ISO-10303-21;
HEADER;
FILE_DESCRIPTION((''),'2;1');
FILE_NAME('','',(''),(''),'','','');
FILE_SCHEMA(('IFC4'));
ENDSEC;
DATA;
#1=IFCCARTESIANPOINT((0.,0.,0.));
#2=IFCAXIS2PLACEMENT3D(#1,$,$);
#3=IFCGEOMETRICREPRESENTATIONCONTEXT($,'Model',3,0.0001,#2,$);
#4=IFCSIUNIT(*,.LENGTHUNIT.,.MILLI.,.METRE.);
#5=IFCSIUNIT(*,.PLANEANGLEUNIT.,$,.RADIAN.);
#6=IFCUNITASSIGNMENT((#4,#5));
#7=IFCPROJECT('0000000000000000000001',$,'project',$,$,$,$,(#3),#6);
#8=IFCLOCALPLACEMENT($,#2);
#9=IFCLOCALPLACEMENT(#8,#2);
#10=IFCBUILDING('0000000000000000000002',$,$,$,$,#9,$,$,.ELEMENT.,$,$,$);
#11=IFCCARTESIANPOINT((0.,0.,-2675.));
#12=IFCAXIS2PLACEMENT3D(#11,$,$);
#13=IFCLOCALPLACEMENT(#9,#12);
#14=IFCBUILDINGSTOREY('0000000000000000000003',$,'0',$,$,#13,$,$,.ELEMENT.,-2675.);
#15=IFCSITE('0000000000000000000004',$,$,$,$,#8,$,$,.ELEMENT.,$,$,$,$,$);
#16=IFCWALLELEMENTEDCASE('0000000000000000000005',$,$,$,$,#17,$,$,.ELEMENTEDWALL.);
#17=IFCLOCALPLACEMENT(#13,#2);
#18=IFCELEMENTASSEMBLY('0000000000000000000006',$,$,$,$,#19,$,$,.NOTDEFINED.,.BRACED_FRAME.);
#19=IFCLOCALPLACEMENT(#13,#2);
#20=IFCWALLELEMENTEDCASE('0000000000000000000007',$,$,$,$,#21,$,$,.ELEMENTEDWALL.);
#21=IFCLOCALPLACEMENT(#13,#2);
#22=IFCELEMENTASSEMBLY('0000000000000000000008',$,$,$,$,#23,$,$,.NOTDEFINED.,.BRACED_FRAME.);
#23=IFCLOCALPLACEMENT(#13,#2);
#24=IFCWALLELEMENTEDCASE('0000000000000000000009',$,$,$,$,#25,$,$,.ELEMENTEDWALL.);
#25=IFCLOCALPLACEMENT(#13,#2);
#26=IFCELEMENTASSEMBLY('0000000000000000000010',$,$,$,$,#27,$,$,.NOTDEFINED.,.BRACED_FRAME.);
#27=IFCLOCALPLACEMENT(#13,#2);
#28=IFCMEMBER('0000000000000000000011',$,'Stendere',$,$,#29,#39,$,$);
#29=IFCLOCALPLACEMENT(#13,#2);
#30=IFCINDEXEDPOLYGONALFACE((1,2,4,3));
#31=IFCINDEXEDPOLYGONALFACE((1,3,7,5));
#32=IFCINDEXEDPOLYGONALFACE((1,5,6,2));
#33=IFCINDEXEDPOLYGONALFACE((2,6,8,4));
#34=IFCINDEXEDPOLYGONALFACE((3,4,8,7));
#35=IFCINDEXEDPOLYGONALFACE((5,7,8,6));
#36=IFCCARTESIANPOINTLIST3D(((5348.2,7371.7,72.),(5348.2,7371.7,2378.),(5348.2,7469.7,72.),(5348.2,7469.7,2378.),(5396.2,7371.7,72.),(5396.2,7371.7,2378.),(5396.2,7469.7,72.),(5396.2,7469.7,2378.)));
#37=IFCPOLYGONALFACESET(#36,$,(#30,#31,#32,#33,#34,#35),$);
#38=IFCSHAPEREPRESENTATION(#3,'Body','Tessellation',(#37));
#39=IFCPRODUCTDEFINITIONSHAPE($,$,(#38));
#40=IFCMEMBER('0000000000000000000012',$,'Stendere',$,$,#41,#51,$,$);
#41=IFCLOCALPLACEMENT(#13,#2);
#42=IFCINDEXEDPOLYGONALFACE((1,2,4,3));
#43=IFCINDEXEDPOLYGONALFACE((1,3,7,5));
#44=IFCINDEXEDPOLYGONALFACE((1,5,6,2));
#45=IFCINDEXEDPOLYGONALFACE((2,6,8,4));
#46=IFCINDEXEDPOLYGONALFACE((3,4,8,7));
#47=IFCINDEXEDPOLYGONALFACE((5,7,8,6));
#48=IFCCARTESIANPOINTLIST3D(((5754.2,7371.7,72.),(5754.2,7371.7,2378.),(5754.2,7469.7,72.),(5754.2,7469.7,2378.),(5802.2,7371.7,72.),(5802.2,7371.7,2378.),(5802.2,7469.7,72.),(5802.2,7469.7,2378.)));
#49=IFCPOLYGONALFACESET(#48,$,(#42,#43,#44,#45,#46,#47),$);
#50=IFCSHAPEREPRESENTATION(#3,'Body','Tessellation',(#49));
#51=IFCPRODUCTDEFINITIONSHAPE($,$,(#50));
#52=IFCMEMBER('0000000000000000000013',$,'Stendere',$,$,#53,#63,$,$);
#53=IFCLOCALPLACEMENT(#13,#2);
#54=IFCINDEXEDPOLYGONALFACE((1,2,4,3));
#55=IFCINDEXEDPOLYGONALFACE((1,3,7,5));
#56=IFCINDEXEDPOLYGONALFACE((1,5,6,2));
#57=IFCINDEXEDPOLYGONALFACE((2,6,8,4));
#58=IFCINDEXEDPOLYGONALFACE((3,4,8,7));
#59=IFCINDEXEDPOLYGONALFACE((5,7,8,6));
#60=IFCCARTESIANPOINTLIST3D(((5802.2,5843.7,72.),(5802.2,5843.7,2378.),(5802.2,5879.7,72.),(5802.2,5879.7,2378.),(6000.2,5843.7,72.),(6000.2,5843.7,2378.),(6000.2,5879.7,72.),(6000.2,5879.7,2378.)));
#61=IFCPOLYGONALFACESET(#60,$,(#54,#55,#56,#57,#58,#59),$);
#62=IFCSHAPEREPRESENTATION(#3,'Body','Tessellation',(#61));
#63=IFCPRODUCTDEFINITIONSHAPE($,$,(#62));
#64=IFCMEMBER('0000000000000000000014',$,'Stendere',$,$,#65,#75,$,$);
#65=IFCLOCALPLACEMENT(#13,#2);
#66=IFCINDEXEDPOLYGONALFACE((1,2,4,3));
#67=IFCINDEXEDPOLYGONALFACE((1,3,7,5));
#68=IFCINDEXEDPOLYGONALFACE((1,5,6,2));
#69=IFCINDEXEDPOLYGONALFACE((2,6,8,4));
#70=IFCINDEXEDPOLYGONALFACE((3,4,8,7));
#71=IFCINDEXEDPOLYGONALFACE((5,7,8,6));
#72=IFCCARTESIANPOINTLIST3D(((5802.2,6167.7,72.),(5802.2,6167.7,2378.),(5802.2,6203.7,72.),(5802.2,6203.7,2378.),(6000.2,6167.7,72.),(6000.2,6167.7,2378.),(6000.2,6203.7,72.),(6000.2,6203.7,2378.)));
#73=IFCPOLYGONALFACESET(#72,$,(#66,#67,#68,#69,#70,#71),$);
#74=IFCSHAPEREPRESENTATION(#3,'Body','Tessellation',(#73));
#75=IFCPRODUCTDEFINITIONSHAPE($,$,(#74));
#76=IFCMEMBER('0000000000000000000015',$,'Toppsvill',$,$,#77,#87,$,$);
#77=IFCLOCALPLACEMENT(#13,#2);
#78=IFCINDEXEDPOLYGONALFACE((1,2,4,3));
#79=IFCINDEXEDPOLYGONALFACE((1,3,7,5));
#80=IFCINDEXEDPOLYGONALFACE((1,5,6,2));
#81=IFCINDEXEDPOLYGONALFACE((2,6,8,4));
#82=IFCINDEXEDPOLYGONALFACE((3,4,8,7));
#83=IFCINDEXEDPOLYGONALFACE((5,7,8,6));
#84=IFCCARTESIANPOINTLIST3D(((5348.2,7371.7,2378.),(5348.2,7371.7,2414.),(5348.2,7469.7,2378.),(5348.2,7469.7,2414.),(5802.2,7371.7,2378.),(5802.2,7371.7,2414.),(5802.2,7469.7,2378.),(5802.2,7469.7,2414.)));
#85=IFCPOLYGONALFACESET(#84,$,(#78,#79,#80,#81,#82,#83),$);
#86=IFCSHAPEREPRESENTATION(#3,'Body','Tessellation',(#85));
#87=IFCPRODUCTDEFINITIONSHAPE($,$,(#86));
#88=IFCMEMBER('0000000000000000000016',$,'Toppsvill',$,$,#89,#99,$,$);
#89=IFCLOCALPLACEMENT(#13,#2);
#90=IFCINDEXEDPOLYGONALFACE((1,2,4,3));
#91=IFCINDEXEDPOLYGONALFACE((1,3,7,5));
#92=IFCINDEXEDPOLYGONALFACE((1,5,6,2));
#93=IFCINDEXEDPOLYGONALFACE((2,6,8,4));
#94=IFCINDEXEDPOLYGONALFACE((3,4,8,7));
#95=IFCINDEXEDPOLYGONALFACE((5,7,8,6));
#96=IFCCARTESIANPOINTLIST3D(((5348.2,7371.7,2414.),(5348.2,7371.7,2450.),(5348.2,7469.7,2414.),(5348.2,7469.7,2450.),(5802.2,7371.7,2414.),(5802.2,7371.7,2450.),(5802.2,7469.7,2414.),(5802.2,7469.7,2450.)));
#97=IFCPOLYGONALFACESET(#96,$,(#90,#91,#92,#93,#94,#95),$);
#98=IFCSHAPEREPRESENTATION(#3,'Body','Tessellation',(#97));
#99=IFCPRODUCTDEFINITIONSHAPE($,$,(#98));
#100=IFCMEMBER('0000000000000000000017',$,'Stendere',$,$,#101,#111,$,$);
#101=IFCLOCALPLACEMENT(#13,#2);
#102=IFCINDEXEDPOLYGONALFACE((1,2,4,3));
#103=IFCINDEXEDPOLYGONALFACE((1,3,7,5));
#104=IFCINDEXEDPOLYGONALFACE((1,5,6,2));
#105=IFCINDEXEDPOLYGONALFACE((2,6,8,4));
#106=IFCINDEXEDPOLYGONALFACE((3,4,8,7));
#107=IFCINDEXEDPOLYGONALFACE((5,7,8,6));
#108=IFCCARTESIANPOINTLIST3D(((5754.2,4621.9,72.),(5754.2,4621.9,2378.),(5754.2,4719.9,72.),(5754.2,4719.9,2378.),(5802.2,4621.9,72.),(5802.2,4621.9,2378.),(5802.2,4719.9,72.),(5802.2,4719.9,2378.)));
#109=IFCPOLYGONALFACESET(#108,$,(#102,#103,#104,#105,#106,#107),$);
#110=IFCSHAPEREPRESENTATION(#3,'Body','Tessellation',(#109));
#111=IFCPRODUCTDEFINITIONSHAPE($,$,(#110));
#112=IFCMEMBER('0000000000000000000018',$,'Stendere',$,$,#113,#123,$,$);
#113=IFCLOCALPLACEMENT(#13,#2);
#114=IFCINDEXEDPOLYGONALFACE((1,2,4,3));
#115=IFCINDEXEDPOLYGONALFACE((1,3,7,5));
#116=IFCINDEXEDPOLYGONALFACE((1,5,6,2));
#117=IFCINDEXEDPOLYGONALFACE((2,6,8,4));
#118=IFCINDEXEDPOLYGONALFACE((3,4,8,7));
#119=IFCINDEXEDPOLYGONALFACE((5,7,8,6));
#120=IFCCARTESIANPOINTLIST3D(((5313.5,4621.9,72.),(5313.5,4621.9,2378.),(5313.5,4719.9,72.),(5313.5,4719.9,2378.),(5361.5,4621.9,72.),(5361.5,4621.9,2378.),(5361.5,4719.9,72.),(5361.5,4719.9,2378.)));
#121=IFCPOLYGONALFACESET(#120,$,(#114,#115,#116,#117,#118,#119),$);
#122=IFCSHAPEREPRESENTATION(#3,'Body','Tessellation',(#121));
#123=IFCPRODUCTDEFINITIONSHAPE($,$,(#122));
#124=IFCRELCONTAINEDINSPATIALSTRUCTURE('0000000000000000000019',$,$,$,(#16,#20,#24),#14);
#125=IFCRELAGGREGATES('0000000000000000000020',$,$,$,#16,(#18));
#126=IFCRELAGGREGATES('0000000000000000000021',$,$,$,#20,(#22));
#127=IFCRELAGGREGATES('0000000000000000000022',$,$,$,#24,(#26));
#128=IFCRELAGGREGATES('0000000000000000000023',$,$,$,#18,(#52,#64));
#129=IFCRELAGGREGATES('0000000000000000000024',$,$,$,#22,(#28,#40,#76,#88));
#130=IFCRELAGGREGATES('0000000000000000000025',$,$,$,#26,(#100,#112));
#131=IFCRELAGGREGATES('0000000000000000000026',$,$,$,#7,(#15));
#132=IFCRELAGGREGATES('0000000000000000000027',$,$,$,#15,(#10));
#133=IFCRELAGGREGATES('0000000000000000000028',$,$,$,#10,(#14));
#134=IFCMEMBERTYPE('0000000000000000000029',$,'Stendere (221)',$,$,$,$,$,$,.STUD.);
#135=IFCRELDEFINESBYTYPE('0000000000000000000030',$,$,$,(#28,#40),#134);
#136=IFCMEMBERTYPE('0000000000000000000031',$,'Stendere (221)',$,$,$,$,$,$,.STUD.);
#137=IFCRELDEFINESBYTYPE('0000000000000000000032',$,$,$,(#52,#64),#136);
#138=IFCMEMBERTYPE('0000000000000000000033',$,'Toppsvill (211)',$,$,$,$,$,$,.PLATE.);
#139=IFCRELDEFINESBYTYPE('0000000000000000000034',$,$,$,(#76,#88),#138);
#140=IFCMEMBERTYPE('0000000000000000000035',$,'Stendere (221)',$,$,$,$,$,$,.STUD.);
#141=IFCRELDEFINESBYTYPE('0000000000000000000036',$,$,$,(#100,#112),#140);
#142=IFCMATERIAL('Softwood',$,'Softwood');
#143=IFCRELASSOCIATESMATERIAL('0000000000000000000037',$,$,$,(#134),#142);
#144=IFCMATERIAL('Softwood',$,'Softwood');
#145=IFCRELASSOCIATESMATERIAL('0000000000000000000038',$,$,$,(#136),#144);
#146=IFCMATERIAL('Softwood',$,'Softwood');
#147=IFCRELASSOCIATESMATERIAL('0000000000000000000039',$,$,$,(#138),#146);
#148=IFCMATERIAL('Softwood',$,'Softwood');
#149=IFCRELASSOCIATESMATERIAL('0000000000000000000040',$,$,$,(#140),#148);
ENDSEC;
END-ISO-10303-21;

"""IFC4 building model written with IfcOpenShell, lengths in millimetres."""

from ifc_helpers import new_model, si_unit, frame, origin, place, context, project, spatial, rectangle, extrude, clip, halfspace, material, material_profile, profile_set, type_object, element, aggregate, save


model = new_model("IFC4")

# Units and contexts
model_context = context("Model", 3, precision=0.0001, world=origin())
ifc_project = project(units=[si_unit("LENGTHUNIT", "METRE", prefix="MILLI"), si_unit("PLANEANGLEUNIT", "RADIAN")], contexts=[model_context])

# Site, building, storey
site_placement = place(None, origin())
site = spatial("IfcSite", under=ifc_project, at=site_placement, CompositionType="ELEMENT")
building_placement = place(site_placement, origin())
building = spatial("IfcBuilding", under=site, at=building_placement, CompositionType="ELEMENT")
storey_placement = place(building_placement, frame((0.0, 0.0, -2675.0)))
storey = spatial("IfcBuildingStorey", under=building, at=storey_placement, Name="0", CompositionType="ELEMENT", Elevation=-2675.0)

# Wall, element assembly
wall_1_placement = place(storey_placement, frame((6000.2, 7469.7, 0.0), z_axis=(-1.0, 0.0, 0.0), x_axis=(0.0, -1.0, 0.0)))
wall_1 = element("IfcWallElementedCase", 1, at=wall_1_placement, inside=storey, PredefinedType="ELEMENTEDWALL")
assembly_1_placement = place(wall_1_placement, origin())
assembly_1 = element("IfcElementAssembly", 2, at=assembly_1_placement, AssemblyPlace="NOTDEFINED", PredefinedType="BRACED_FRAME")
aggregate(wall_1, [assembly_1])

# Wall, element assembly
wall_2_placement = place(storey_placement, frame((5802.2, 7371.7, 0.0), z_axis=(0.0, 1.0, 0.0), x_axis=(-1.0, 0.0, 0.0)))
wall_2 = element("IfcWallElementedCase", 3, at=wall_2_placement, inside=storey, PredefinedType="ELEMENTEDWALL")
assembly_2_placement = place(wall_2_placement, origin())
assembly_2 = element("IfcElementAssembly", 4, at=assembly_2_placement, AssemblyPlace="NOTDEFINED", PredefinedType="BRACED_FRAME")
aggregate(wall_2, [assembly_2])

# Wall, element assembly
wall_3_placement = place(storey_placement, frame((352.0, 4719.9, 0.0), z_axis=(0.0, -1.0, 0.0)))
wall_3 = element("IfcWallElementedCase", 5, at=wall_3_placement, inside=storey, PredefinedType="ELEMENTEDWALL")
assembly_3_placement = place(wall_3_placement, origin())
assembly_3 = element("IfcElementAssembly", 6, at=assembly_3_placement, AssemblyPlace="NOTDEFINED", PredefinedType="BRACED_FRAME")
aggregate(wall_3, [assembly_3])
ifc_material_1 = material(Name="Softwood", Category="Softwood")
ifc_material_profile_1 = material_profile(ifc_material_1, rectangle(XDim=48.0, YDim=98.0), Name="Stendere (221)")
ifc_profile_set_1 = profile_set([ifc_material_profile_1])
member_type_1 = type_object("IfcMemberType", Name="Stendere (221)", PredefinedType="STUD", material=ifc_profile_set_1)

# Members
member_1_placement = place(assembly_2_placement, frame((430.0, 72.0, 0.0), z_axis=(0.0, 1.0, 0.0), x_axis=(-1.0, 0.0, 0.0)))
member_1 = element("IfcMember", 7, at=member_1_placement, type_object=member_type_1, Name="Stendere", context=model_context, shape_type="SweptSolid", body=[
    extrude(rectangle(XDim=48.0, YDim=98.0), frame((0.0, 49.0, 0.0)), (0.0, 0.0, 1.0), 2306.0),
])
member_2_placement = place(assembly_2_placement, frame((24.0, 72.0, 0.0), z_axis=(0.0, 1.0, 0.0), x_axis=(-1.0, 0.0, 0.0)))
member_2 = element("IfcMember", 8, at=member_2_placement, type_object=member_type_1, Name="Stendere", context=model_context, shape_type="SweptSolid", body=[
    extrude(rectangle(XDim=48.0, YDim=98.0), frame((0.0, 49.0, 0.0)), (0.0, 0.0, 1.0), 2306.0),
])
ifc_material_2 = material(Name="Softwood", Category="Softwood")
ifc_material_profile_2 = material_profile(ifc_material_2, rectangle(XDim=36.0, YDim=198.0), Name="Stendere (221)")
ifc_profile_set_2 = profile_set([ifc_material_profile_2])
member_type_2 = type_object("IfcMemberType", Name="Stendere (221)", PredefinedType="STUD", material=ifc_profile_set_2)
member_3_placement = place(assembly_1_placement, frame((1608.0, 72.0, 0.0), z_axis=(0.0, 1.0, 0.0), x_axis=(-1.0, 0.0, 0.0)))
member_3 = element("IfcMember", 9, at=member_3_placement, type_object=member_type_2, Name="Stendere", context=model_context, shape_type="SweptSolid", body=[
    extrude(rectangle(XDim=36.0, YDim=198.0), frame((0.0, 99.0, 0.0)), (0.0, 0.0, 1.0), 2306.0),
])
member_4_placement = place(assembly_1_placement, frame((1284.0, 72.0, 0.0), z_axis=(0.0, 1.0, 0.0), x_axis=(-1.0, 0.0, 0.0)))
member_4 = element("IfcMember", 10, at=member_4_placement, type_object=member_type_2, Name="Stendere", context=model_context, shape_type="SweptSolid", body=[
    extrude(rectangle(XDim=36.0, YDim=198.0), frame((0.0, 99.0, 0.0)), (0.0, 0.0, 1.0), 2306.0),
])
aggregate(assembly_1, [member_3, member_4])
ifc_material_3 = material(Name="Softwood", Category="Softwood")
ifc_material_profile_3 = material_profile(ifc_material_3, rectangle(XDim=36.0, YDim=98.0), Name="Toppsvill (211)")
ifc_profile_set_3 = profile_set([ifc_material_profile_3])
member_type_3 = type_object("IfcMemberType", Name="Toppsvill (211)", PredefinedType="PLATE", material=ifc_profile_set_3)
member_5_placement = place(assembly_2_placement, frame((0.0, 2396.0, 0.0), z_axis=(1.0, 0.0, 0.0), x_axis=(0.0, 1.0, 0.0)))
member_5 = element("IfcMember", 11, at=member_5_placement, type_object=member_type_3, Name="Toppsvill", context=model_context, shape_type="SweptSolid", body=[
    extrude(rectangle(XDim=36.0, YDim=98.0), frame((0.0, 49.0, 0.0)), (0.0, 0.0, 1.0), 454.0),
])
member_6_placement = place(assembly_2_placement, frame((0.0, 2432.0, 0.0), z_axis=(1.0, 0.0, 0.0), x_axis=(0.0, 1.0, 0.0)))
member_6 = element("IfcMember", 12, at=member_6_placement, type_object=member_type_3, Name="Toppsvill", context=model_context, shape_type="Clipping", body=[
    clip(extrude(rectangle(XDim=36.0, YDim=98.0), frame((0.0, 49.0, 0.0)), (0.0, 0.0, 1.0), 454.0), halfspace(frame((0.0, 49.0, 0.0)), True)),
])
aggregate(assembly_2, [member_1, member_2, member_5, member_6])
ifc_material_4 = material(Name="Softwood", Category="Softwood")
ifc_material_profile_4 = material_profile(ifc_material_4, rectangle(XDim=48.0, YDim=98.0), Name="Stendere (221)")
ifc_profile_set_4 = profile_set([ifc_material_profile_4])
member_type_4 = type_object("IfcMemberType", Name="Stendere (221)", PredefinedType="STUD", material=ifc_profile_set_4)
member_7_placement = place(assembly_3_placement, frame((5426.2, 72.0, 0.0), z_axis=(0.0, 1.0, 0.0), x_axis=(-1.0, 0.0, 0.0)))
member_7 = element("IfcMember", 13, at=member_7_placement, type_object=member_type_4, Name="Stendere", context=model_context, shape_type="SweptSolid", body=[
    extrude(rectangle(XDim=48.0, YDim=98.0), frame((0.0, 49.0, 0.0)), (0.0, 0.0, 1.0), 2306.0),
])
member_8_placement = place(assembly_3_placement, frame((4985.5, 72.0, 0.0), z_axis=(0.0, 1.0, 0.0), x_axis=(-1.0, 0.0, 0.0)))
member_8 = element("IfcMember", 14, at=member_8_placement, type_object=member_type_4, Name="Stendere", context=model_context, shape_type="SweptSolid", body=[
    extrude(rectangle(XDim=48.0, YDim=98.0), frame((0.0, 49.0, 0.0)), (0.0, 0.0, 1.0), 2306.0),
])
aggregate(assembly_3, [member_7, member_8])

save(model, "model.ifc")
